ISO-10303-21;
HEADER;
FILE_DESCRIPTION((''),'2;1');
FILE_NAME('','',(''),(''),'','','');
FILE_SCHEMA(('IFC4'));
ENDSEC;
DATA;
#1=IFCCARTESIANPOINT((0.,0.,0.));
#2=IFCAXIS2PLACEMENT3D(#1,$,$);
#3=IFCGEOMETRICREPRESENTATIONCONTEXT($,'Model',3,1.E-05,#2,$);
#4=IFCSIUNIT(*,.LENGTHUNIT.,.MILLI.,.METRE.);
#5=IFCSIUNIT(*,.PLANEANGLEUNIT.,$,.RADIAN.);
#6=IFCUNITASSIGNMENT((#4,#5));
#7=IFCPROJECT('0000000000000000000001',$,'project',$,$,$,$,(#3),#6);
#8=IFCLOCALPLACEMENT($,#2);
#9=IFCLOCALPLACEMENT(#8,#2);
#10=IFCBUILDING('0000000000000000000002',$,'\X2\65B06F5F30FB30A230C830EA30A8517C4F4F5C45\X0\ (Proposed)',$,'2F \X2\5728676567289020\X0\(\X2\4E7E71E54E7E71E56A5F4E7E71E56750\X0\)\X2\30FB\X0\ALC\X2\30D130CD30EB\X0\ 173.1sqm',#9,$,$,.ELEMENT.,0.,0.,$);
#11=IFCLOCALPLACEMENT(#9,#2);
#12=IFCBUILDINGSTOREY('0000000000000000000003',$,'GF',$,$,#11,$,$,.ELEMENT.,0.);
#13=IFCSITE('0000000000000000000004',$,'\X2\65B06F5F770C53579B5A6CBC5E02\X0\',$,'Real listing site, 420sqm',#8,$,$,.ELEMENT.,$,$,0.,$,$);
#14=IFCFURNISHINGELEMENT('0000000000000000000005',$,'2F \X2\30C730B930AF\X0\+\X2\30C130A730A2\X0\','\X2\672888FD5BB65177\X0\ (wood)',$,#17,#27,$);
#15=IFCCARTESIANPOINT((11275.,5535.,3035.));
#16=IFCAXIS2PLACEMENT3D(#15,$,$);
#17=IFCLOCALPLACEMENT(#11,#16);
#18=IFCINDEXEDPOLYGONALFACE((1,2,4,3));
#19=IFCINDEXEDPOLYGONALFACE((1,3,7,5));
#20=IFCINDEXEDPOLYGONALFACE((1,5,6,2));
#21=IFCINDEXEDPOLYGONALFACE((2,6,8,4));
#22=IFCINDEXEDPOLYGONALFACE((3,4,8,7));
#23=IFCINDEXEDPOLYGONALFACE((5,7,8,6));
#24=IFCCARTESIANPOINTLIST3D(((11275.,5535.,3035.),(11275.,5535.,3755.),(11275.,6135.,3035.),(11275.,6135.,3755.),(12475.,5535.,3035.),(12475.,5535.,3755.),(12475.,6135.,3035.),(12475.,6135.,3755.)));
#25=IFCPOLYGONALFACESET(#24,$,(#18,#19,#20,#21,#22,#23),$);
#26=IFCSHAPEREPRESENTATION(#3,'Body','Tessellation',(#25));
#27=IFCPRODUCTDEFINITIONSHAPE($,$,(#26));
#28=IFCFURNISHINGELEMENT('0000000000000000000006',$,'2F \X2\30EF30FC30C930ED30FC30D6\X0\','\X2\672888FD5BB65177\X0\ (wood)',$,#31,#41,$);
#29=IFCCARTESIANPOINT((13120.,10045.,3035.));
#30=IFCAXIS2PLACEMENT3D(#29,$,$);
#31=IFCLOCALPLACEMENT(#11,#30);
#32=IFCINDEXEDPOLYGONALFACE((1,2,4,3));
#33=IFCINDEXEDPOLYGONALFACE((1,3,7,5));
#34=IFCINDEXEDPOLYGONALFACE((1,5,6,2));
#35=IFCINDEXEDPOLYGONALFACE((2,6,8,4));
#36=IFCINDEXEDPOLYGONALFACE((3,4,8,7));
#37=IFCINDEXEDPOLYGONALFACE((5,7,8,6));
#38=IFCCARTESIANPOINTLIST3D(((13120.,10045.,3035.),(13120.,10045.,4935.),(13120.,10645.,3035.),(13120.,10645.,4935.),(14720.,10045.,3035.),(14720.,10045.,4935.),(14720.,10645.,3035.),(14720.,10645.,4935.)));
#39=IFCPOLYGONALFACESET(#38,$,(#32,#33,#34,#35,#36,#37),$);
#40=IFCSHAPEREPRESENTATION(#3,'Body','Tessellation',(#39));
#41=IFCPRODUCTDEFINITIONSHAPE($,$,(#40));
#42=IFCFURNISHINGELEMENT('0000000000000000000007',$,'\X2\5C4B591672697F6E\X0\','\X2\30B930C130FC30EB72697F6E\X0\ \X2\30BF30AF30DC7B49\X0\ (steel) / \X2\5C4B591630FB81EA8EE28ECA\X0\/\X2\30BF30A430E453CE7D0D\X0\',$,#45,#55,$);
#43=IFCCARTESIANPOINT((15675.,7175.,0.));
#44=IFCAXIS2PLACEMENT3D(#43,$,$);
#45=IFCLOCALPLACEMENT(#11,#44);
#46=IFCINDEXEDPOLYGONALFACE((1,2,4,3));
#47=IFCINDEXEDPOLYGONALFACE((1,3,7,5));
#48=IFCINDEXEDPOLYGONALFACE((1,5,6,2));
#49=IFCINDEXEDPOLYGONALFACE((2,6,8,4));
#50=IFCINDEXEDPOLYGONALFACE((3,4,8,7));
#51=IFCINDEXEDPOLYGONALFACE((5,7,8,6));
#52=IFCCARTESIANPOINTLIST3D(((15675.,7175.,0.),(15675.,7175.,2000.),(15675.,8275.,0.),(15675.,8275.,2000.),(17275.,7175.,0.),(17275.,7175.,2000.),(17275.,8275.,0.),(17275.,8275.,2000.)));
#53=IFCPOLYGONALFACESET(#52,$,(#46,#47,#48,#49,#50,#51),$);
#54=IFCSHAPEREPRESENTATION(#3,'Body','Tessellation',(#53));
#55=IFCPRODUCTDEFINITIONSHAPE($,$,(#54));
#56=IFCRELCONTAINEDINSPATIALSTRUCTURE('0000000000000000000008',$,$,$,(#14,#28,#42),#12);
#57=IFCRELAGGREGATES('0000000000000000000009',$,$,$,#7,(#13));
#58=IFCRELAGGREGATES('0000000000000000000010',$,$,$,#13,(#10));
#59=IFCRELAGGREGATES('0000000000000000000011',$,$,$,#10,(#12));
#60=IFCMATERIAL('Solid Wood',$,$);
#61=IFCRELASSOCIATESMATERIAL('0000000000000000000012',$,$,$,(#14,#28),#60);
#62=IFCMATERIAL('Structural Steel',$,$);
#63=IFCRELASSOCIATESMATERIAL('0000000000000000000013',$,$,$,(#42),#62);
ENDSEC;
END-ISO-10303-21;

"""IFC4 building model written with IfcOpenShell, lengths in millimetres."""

from ifc_helpers import new_model, si_unit, frame, frame_2d, origin, place, context, project, spatial, rectangle, extrude, material, element, save


model = new_model("IFC4")

# Units and contexts
model_context = context("Model", 3, precision=1e-05, world=origin())
ifc_project = project(units=[si_unit("LENGTHUNIT", "METRE", prefix="MILLI"), si_unit("PLANEANGLEUNIT", "RADIAN")], contexts=[model_context])

# Site, building, storey
site_placement = place(None, origin())
site = spatial("IfcSite", under=ifc_project, at=site_placement, Name="新潟県南魚沼市", ObjectType="Real listing site, 420sqm", CompositionType="ELEMENT", RefElevation=0.0)
building_placement = place(site_placement, origin())
building = spatial("IfcBuilding", under=site, at=building_placement, Name="新潟・アトリエ兼住居 (Proposed)", ObjectType="2F 在来木造(乾燥乾燥機乾燥材)・ALCパネル 173.1sqm", CompositionType="ELEMENT", ElevationOfRefHeight=0.0, ElevationOfTerrain=0.0)
storey_placement = place(building_placement, origin())
storey = spatial("IfcBuildingStorey", under=building, at=storey_placement, Name="GF", CompositionType="ELEMENT", Elevation=0.0)

# Shared definitions
ifc_material_1 = material(Name="Solid Wood")

# Shared definitions
ifc_material_2 = material(Name="Structural Steel")

# Furnishing elements
furnishing_1_placement = place(storey_placement, frame((11275.0, 5535.0, 3035.0)))
element("IfcFurnishingElement", 1, at=furnishing_1_placement, inside=storey, material=ifc_material_1, Name="2F デスク+チェア", Description="木製家具 (wood)", context=model_context, shape_type="SweptSolid", body=[
    extrude(rectangle(XDim=1200.0, YDim=600.0, at=frame_2d((600.0, 300.0))), frame((11275.0, 5535.0, 3035.0)), (0.0, 0.0, 1.0), 720.0),
])
furnishing_2_placement = place(storey_placement, frame((13120.0, 10045.0, 3035.0)))
element("IfcFurnishingElement", 2, at=furnishing_2_placement, inside=storey, material=ifc_material_1, Name="2F ワードローブ", Description="木製家具 (wood)", context=model_context, shape_type="SweptSolid", body=[
    extrude(rectangle(XDim=1600.0, YDim=600.0, at=frame_2d((800.0, 300.0))), frame((13120.0, 10045.0, 3035.0)), (0.0, 0.0, 1.0), 1900.0),
])
furnishing_3_placement = place(storey_placement, frame((15675.0, 7175.0, 0.0)))
element("IfcFurnishingElement", 3, at=furnishing_3_placement, inside=storey, material=ifc_material_2, Name="屋外物置", Description="スチール物置 タクボ等 (steel) / 屋外・自転車/タイヤ収納", context=model_context, shape_type="SweptSolid", body=[
    extrude(rectangle(XDim=1600.0, YDim=1100.0, at=frame_2d((800.0, 550.0))), frame((15675.0, 7175.0, 0.0)), (0.0, 0.0, 1.0), 2000.0),
])

save(model, "model.ifc")
